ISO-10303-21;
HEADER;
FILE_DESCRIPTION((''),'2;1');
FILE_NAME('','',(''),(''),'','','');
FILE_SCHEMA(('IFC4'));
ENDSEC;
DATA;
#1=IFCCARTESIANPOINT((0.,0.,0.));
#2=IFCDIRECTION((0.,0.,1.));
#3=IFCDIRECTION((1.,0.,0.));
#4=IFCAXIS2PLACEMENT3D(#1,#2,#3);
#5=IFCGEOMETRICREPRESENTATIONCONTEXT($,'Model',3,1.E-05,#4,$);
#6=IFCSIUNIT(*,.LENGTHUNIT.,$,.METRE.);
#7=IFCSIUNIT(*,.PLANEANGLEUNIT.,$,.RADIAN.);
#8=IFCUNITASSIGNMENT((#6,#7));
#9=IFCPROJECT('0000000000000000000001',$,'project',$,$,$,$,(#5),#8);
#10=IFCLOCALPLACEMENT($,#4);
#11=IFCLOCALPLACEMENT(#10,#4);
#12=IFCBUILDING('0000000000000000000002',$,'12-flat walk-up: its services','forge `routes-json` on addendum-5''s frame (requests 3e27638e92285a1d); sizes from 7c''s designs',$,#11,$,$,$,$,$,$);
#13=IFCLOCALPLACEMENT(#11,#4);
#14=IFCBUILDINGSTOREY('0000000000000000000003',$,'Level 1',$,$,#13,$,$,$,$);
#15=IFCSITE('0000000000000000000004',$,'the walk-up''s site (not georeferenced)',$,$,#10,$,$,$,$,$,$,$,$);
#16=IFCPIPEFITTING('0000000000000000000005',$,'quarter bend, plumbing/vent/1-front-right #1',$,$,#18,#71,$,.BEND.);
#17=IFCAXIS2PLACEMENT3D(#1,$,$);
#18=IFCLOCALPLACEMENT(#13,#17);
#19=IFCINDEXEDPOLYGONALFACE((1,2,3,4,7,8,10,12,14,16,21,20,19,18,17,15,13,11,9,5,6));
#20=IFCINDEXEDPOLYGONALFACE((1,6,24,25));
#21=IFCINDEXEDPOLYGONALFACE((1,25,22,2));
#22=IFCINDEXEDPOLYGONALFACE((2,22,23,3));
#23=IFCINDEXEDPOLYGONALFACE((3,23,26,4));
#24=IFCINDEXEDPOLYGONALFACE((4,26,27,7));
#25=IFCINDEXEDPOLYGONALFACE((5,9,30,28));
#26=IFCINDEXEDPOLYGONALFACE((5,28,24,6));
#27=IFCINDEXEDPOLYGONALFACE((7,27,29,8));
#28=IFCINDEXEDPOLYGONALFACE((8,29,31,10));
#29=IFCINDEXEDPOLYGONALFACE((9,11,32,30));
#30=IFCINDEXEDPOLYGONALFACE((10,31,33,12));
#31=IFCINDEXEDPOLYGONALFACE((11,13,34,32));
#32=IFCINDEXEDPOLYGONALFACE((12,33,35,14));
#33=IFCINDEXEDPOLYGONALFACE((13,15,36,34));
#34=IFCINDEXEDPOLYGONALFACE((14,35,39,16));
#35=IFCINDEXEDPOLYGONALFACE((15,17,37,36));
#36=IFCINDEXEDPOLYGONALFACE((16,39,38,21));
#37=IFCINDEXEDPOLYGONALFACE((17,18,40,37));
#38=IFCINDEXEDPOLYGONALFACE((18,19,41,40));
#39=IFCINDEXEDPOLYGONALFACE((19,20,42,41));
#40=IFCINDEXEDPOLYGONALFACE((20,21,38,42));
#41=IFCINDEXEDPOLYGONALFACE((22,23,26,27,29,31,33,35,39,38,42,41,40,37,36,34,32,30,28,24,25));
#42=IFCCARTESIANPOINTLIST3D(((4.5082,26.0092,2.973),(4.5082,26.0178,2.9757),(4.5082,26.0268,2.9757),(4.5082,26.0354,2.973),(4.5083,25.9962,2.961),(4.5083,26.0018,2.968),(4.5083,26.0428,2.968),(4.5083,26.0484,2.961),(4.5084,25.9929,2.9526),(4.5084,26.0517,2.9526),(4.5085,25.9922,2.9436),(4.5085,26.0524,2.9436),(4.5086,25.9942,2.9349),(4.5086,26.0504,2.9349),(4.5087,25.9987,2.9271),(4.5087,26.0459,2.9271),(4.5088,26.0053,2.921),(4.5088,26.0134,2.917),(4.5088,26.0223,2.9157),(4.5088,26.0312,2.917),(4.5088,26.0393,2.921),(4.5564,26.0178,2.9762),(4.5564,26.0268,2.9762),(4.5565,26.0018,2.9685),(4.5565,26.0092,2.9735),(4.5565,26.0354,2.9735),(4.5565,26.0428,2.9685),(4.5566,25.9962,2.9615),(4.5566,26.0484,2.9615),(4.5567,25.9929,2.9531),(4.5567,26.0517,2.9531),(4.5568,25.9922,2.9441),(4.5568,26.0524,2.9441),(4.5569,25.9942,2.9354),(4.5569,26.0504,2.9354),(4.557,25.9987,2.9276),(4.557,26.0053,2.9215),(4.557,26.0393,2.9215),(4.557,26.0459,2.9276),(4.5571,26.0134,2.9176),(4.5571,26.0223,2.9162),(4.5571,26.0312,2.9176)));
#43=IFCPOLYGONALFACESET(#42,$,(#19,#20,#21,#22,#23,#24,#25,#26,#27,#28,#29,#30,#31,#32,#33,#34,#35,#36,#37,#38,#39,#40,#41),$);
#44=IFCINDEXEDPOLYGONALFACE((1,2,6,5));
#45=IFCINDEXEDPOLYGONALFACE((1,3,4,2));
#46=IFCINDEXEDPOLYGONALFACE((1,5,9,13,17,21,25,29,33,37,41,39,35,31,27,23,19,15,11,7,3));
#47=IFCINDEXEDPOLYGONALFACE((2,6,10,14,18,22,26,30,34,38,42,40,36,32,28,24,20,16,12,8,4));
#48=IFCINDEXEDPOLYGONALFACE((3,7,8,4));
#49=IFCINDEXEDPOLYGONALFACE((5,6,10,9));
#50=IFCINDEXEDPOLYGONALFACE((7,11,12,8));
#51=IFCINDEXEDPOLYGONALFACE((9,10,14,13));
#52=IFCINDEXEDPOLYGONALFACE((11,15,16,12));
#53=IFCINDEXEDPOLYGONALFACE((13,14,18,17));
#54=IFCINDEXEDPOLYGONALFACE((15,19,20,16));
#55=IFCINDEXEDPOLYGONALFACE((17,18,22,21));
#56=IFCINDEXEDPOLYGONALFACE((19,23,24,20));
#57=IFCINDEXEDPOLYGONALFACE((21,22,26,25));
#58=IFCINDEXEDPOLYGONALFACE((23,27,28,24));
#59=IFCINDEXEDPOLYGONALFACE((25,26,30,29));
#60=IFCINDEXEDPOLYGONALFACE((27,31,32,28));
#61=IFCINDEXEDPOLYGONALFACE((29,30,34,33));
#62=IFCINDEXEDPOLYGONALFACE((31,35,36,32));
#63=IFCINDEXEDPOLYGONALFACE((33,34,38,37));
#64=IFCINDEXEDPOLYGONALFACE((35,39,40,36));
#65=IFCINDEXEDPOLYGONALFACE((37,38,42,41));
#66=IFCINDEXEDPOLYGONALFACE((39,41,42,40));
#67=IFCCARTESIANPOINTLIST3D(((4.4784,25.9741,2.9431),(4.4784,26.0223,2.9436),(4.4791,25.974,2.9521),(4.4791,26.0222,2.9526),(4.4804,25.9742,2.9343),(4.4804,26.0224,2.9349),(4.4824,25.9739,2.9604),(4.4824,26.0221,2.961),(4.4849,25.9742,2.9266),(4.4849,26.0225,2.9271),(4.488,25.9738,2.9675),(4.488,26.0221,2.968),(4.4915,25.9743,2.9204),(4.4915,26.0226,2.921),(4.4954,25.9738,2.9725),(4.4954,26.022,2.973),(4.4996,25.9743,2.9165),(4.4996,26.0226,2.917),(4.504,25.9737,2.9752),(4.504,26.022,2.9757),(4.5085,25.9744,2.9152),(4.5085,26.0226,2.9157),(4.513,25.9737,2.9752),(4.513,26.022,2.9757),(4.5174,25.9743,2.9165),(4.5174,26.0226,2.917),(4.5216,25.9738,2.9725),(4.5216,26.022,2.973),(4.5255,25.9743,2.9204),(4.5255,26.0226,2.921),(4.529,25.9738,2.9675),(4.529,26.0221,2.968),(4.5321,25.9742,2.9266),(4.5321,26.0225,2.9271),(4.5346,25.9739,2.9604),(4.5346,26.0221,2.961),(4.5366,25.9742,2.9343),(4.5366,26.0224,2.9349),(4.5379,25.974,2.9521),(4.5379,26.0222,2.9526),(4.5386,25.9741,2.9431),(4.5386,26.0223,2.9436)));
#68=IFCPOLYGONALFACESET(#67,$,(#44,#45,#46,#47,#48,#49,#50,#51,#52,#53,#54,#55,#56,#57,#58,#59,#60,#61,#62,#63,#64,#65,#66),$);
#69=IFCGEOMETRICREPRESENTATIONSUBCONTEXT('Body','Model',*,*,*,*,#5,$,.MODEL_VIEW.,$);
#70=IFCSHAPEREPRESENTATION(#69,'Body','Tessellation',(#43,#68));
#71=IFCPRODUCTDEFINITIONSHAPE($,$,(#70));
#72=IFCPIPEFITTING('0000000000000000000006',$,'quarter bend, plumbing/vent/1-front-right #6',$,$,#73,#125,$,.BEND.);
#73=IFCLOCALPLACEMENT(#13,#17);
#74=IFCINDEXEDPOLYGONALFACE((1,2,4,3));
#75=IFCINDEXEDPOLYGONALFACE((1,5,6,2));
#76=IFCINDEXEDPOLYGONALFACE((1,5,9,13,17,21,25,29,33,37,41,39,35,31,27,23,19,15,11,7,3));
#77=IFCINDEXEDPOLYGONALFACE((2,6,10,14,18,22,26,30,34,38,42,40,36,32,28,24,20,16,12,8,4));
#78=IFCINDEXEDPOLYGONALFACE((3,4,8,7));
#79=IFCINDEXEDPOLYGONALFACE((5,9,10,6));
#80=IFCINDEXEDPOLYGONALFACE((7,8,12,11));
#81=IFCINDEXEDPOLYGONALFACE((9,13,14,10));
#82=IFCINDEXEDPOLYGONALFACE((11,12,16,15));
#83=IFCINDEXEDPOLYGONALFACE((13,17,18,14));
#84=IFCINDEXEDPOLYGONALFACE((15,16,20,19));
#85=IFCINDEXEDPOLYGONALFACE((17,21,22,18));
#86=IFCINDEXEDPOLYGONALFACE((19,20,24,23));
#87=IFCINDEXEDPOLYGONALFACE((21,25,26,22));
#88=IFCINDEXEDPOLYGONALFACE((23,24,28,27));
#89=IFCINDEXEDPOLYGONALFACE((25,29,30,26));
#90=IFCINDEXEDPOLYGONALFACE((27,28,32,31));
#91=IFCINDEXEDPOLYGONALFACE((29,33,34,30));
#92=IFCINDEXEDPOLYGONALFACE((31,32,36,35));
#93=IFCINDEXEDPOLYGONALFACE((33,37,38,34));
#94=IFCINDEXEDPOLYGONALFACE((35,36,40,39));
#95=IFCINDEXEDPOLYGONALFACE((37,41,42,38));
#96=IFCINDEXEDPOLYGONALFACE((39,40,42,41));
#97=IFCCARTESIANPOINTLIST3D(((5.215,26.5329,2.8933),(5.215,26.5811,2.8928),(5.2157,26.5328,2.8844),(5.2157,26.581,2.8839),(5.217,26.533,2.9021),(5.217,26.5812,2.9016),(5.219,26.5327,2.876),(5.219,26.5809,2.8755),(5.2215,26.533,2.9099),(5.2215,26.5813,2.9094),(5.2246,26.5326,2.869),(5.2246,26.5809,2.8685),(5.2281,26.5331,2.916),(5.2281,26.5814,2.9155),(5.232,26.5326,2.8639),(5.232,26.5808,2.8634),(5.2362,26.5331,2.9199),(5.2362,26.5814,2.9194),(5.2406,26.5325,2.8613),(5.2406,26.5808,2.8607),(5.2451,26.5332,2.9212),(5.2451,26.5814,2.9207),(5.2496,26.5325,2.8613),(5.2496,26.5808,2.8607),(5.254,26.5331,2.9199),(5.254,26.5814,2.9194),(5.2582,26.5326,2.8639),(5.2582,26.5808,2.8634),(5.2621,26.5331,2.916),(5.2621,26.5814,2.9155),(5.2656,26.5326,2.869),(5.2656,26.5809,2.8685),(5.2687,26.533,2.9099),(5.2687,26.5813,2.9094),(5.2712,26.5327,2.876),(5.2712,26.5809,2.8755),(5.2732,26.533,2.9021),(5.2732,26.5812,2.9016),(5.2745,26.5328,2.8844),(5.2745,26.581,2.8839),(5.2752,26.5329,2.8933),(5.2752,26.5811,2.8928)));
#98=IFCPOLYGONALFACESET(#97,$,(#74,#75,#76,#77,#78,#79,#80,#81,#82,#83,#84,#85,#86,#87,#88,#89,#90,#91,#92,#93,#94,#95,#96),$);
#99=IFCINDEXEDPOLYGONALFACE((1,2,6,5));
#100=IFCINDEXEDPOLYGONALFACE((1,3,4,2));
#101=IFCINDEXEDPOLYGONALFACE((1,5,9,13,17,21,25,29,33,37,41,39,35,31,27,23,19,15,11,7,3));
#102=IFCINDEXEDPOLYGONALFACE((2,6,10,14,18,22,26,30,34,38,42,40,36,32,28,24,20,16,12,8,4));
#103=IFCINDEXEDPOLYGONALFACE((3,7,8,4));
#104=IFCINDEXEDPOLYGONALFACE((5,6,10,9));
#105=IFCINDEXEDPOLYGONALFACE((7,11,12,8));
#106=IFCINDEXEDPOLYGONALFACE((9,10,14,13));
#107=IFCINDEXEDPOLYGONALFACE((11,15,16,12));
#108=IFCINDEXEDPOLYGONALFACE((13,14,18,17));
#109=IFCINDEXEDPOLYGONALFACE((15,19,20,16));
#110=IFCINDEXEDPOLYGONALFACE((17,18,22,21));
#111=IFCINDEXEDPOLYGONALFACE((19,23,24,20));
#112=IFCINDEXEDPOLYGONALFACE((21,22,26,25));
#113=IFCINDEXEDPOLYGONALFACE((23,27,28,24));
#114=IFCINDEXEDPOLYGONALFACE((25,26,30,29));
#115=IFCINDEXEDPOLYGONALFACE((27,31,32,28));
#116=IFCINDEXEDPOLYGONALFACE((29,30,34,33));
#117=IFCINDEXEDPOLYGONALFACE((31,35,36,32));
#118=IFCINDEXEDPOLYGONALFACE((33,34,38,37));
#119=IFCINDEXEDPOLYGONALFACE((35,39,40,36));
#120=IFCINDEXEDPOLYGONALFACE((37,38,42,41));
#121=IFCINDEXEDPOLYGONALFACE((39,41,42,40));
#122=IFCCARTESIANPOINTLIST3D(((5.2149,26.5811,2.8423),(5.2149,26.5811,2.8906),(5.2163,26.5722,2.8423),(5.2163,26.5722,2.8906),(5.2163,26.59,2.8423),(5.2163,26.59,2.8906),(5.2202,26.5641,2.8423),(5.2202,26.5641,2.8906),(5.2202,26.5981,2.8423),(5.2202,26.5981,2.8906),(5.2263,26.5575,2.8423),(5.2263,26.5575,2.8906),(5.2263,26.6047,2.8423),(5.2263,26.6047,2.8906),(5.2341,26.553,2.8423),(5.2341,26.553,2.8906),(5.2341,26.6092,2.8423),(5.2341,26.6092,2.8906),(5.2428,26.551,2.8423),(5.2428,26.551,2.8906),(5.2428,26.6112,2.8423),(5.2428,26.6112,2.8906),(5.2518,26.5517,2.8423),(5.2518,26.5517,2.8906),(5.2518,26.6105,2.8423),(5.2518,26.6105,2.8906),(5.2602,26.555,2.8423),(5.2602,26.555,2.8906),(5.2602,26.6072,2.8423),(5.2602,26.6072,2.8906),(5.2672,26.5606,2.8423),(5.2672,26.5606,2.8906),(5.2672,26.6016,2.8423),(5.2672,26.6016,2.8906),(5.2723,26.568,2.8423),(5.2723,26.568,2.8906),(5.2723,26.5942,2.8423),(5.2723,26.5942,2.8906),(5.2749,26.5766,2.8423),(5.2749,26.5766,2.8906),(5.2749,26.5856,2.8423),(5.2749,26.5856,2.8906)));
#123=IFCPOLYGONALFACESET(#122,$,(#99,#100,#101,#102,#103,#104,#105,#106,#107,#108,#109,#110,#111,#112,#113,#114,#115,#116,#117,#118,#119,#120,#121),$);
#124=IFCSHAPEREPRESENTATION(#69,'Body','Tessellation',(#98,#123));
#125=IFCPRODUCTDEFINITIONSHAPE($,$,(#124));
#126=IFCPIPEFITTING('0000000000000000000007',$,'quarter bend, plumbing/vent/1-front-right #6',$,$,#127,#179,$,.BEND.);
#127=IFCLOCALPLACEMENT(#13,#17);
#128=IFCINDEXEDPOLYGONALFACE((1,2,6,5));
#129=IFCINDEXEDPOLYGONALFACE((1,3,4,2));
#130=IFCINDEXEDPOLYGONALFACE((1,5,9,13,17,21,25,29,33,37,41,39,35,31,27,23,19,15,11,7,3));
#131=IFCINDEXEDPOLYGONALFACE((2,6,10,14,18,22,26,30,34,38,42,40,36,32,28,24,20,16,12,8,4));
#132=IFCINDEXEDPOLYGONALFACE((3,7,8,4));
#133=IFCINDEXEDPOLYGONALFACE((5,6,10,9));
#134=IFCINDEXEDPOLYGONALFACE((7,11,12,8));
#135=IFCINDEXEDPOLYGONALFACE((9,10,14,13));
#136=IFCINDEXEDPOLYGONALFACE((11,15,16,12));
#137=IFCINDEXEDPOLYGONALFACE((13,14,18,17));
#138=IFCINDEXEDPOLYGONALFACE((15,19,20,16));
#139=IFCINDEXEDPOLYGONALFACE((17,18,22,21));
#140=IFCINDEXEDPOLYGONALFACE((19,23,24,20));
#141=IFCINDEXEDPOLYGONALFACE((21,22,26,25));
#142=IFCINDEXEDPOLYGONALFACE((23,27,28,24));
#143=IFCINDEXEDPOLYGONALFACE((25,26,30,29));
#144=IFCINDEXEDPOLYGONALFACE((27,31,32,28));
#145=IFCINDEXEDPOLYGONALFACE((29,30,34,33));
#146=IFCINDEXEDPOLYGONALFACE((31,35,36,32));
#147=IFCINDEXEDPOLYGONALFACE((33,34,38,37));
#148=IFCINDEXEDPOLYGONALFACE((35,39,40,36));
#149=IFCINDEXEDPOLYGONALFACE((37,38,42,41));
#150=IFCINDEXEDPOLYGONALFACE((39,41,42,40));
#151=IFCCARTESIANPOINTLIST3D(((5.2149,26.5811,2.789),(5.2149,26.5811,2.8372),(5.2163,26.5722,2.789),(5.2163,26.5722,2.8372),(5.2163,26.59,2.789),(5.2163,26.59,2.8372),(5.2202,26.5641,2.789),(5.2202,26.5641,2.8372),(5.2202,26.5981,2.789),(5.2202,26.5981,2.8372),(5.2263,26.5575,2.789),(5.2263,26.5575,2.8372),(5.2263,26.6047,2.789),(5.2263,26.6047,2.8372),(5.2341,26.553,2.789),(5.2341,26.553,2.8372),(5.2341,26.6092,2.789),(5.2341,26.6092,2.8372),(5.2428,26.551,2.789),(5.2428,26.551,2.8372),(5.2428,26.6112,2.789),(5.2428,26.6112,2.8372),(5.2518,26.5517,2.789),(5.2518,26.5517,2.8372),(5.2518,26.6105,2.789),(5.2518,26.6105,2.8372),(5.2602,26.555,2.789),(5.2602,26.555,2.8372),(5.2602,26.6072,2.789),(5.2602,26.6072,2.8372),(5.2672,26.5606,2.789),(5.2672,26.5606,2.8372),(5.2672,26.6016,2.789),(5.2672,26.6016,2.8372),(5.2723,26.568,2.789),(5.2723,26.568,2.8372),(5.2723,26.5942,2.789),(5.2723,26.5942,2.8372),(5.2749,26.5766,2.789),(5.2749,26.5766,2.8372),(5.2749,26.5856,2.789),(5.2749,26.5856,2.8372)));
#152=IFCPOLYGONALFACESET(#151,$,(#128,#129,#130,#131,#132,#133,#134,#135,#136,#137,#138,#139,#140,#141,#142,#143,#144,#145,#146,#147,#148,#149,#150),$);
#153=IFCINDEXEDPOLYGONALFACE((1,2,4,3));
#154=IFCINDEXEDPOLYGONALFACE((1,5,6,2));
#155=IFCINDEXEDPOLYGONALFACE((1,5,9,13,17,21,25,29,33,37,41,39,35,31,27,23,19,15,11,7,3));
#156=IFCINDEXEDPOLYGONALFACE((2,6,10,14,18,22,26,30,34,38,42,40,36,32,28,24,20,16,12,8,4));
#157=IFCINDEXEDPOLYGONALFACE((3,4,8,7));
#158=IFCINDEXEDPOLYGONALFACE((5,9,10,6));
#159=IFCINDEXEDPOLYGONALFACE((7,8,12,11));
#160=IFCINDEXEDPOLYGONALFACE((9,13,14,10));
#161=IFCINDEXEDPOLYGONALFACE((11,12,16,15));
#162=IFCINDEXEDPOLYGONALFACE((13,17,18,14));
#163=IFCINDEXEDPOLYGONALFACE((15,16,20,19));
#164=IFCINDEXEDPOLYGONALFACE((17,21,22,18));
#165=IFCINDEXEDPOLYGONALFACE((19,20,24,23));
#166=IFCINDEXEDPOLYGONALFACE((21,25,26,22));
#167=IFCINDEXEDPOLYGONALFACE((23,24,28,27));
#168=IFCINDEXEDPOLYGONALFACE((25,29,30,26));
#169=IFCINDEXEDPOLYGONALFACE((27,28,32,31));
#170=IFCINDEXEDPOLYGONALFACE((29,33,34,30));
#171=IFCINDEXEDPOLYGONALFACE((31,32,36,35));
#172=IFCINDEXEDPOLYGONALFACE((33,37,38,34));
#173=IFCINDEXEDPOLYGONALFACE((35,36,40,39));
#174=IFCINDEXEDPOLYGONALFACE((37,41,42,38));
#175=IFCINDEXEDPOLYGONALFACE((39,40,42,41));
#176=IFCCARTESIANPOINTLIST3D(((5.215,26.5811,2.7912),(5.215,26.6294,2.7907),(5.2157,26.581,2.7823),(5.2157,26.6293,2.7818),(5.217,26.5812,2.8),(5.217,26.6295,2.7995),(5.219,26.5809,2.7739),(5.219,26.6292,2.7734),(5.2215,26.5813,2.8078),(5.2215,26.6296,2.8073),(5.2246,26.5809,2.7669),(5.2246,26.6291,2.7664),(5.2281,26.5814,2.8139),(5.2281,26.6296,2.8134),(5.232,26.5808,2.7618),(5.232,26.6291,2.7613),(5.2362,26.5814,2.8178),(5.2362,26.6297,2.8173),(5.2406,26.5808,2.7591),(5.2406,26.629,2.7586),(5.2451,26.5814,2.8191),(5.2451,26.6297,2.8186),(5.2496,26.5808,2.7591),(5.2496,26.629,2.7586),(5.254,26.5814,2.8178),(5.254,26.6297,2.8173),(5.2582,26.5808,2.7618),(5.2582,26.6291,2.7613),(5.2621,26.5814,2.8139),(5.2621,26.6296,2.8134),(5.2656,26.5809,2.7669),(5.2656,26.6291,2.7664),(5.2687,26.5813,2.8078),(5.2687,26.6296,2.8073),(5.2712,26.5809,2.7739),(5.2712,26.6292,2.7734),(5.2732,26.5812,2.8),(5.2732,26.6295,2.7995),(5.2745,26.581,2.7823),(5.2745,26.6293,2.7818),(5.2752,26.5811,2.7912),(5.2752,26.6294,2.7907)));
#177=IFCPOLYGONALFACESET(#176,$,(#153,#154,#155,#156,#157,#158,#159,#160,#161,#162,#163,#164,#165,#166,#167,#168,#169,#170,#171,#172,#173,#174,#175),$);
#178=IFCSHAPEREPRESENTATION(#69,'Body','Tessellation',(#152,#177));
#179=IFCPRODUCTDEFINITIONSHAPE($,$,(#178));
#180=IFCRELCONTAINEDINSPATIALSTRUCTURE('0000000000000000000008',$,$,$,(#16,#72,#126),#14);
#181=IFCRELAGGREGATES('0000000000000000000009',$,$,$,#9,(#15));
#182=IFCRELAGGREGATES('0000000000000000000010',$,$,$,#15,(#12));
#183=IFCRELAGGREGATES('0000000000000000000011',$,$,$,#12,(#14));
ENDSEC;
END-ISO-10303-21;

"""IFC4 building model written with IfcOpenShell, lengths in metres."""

from ifc_helpers import new_model, entity, si_unit, frame, origin_with_axes, place, context, subcontext, project, spatial, element, save


model = new_model("IFC4")

# Units and contexts
model_context = context("Model", 3, precision=1e-05, world=origin_with_axes())
body_context = subcontext(model_context, "Body", "Model", "MODEL_VIEW")
ifc_project = project(units=[si_unit("LENGTHUNIT", "METRE"), si_unit("PLANEANGLEUNIT", "RADIAN")], contexts=[model_context])

# Site, building, storey
site_placement = place(None, origin_with_axes())
site = spatial("IfcSite", under=ifc_project, at=site_placement, Name="the walk-up's site (not georeferenced)")
building_placement = place(site_placement, origin_with_axes())
building = spatial("IfcBuilding", under=site, at=building_placement, Name="12-flat walk-up: its services", Description="forge `routes-json` on addendum-5's frame (requests 3e27638e92285a1d); sizes from 7c's designs")
storey_placement = place(building_placement, origin_with_axes())
storey = spatial("IfcBuildingStorey", under=building, at=storey_placement, Name="Level 1")

# Pipe fitting
pipe_fitting_1_placement = place(storey_placement, frame((4.5568, 26.0223, 2.9464), z_axis=(0.0, 0.0, 1.0), x_axis=(1.0, 0.0, 0.0)))
element("IfcPipeFitting", 1, at=pipe_fitting_1_placement, inside=storey, Name="quarter bend, plumbing/vent/1-front-right #1", PredefinedType="BEND", context=body_context, shape_type="AdvancedSweptSolid", body=[
    entity("IfcSweptDiskSolid", entity("IfcPolyline", [entity("IfcCartesianPoint", [0.0, 0.0, 0.0]), entity("IfcCartesianPoint", [-0.0483, 0.0, -0.0005])]), 0.0302),
    entity("IfcSweptDiskSolid", entity("IfcPolyline", [entity("IfcCartesianPoint", [-0.0483, 0.0, -0.0005]), entity("IfcCartesianPoint", [-0.0483, -0.0483, -0.001])]), 0.0302),
])

# Pipe fittings
pipe_fitting_2_placement = place(storey_placement, frame((5.2451, 26.5328, 2.8911), z_axis=(0.0, 0.0, 1.0), x_axis=(1.0, 0.0, 0.0)))
element("IfcPipeFitting", 2, at=pipe_fitting_2_placement, inside=storey, Name="quarter bend, plumbing/vent/1-front-right #6", PredefinedType="BEND", context=body_context, shape_type="AdvancedSweptSolid", body=[
    entity("IfcSweptDiskSolid", entity("IfcPolyline", [entity("IfcCartesianPoint", [0.0, 0.0, 0.0]), entity("IfcCartesianPoint", [0.0, 0.0483, -0.0005])]), 0.0302),
    entity("IfcSweptDiskSolid", entity("IfcPolyline", [entity("IfcCartesianPoint", [0.0, 0.0483, -0.0005]), entity("IfcCartesianPoint", [0.0, 0.0483, -0.0488])]), 0.0302),
])
pipe_fitting_3_placement = place(storey_placement, frame((5.2451, 26.5811, 2.8372), z_axis=(0.0, 0.0, 1.0), x_axis=(1.0, 0.0, 0.0)))
element("IfcPipeFitting", 3, at=pipe_fitting_3_placement, inside=storey, Name="quarter bend, plumbing/vent/1-front-right #6", PredefinedType="BEND", context=body_context, shape_type="AdvancedSweptSolid", body=[
    entity("IfcSweptDiskSolid", entity("IfcPolyline", [entity("IfcCartesianPoint", [0.0, 0.0, 0.0]), entity("IfcCartesianPoint", [0.0, 0.0, -0.0483])]), 0.0302),
    entity("IfcSweptDiskSolid", entity("IfcPolyline", [entity("IfcCartesianPoint", [0.0, 0.0, -0.0483]), entity("IfcCartesianPoint", [0.0, 0.0483, -0.0488])]), 0.0302),
])

save(model, "model.ifc")
